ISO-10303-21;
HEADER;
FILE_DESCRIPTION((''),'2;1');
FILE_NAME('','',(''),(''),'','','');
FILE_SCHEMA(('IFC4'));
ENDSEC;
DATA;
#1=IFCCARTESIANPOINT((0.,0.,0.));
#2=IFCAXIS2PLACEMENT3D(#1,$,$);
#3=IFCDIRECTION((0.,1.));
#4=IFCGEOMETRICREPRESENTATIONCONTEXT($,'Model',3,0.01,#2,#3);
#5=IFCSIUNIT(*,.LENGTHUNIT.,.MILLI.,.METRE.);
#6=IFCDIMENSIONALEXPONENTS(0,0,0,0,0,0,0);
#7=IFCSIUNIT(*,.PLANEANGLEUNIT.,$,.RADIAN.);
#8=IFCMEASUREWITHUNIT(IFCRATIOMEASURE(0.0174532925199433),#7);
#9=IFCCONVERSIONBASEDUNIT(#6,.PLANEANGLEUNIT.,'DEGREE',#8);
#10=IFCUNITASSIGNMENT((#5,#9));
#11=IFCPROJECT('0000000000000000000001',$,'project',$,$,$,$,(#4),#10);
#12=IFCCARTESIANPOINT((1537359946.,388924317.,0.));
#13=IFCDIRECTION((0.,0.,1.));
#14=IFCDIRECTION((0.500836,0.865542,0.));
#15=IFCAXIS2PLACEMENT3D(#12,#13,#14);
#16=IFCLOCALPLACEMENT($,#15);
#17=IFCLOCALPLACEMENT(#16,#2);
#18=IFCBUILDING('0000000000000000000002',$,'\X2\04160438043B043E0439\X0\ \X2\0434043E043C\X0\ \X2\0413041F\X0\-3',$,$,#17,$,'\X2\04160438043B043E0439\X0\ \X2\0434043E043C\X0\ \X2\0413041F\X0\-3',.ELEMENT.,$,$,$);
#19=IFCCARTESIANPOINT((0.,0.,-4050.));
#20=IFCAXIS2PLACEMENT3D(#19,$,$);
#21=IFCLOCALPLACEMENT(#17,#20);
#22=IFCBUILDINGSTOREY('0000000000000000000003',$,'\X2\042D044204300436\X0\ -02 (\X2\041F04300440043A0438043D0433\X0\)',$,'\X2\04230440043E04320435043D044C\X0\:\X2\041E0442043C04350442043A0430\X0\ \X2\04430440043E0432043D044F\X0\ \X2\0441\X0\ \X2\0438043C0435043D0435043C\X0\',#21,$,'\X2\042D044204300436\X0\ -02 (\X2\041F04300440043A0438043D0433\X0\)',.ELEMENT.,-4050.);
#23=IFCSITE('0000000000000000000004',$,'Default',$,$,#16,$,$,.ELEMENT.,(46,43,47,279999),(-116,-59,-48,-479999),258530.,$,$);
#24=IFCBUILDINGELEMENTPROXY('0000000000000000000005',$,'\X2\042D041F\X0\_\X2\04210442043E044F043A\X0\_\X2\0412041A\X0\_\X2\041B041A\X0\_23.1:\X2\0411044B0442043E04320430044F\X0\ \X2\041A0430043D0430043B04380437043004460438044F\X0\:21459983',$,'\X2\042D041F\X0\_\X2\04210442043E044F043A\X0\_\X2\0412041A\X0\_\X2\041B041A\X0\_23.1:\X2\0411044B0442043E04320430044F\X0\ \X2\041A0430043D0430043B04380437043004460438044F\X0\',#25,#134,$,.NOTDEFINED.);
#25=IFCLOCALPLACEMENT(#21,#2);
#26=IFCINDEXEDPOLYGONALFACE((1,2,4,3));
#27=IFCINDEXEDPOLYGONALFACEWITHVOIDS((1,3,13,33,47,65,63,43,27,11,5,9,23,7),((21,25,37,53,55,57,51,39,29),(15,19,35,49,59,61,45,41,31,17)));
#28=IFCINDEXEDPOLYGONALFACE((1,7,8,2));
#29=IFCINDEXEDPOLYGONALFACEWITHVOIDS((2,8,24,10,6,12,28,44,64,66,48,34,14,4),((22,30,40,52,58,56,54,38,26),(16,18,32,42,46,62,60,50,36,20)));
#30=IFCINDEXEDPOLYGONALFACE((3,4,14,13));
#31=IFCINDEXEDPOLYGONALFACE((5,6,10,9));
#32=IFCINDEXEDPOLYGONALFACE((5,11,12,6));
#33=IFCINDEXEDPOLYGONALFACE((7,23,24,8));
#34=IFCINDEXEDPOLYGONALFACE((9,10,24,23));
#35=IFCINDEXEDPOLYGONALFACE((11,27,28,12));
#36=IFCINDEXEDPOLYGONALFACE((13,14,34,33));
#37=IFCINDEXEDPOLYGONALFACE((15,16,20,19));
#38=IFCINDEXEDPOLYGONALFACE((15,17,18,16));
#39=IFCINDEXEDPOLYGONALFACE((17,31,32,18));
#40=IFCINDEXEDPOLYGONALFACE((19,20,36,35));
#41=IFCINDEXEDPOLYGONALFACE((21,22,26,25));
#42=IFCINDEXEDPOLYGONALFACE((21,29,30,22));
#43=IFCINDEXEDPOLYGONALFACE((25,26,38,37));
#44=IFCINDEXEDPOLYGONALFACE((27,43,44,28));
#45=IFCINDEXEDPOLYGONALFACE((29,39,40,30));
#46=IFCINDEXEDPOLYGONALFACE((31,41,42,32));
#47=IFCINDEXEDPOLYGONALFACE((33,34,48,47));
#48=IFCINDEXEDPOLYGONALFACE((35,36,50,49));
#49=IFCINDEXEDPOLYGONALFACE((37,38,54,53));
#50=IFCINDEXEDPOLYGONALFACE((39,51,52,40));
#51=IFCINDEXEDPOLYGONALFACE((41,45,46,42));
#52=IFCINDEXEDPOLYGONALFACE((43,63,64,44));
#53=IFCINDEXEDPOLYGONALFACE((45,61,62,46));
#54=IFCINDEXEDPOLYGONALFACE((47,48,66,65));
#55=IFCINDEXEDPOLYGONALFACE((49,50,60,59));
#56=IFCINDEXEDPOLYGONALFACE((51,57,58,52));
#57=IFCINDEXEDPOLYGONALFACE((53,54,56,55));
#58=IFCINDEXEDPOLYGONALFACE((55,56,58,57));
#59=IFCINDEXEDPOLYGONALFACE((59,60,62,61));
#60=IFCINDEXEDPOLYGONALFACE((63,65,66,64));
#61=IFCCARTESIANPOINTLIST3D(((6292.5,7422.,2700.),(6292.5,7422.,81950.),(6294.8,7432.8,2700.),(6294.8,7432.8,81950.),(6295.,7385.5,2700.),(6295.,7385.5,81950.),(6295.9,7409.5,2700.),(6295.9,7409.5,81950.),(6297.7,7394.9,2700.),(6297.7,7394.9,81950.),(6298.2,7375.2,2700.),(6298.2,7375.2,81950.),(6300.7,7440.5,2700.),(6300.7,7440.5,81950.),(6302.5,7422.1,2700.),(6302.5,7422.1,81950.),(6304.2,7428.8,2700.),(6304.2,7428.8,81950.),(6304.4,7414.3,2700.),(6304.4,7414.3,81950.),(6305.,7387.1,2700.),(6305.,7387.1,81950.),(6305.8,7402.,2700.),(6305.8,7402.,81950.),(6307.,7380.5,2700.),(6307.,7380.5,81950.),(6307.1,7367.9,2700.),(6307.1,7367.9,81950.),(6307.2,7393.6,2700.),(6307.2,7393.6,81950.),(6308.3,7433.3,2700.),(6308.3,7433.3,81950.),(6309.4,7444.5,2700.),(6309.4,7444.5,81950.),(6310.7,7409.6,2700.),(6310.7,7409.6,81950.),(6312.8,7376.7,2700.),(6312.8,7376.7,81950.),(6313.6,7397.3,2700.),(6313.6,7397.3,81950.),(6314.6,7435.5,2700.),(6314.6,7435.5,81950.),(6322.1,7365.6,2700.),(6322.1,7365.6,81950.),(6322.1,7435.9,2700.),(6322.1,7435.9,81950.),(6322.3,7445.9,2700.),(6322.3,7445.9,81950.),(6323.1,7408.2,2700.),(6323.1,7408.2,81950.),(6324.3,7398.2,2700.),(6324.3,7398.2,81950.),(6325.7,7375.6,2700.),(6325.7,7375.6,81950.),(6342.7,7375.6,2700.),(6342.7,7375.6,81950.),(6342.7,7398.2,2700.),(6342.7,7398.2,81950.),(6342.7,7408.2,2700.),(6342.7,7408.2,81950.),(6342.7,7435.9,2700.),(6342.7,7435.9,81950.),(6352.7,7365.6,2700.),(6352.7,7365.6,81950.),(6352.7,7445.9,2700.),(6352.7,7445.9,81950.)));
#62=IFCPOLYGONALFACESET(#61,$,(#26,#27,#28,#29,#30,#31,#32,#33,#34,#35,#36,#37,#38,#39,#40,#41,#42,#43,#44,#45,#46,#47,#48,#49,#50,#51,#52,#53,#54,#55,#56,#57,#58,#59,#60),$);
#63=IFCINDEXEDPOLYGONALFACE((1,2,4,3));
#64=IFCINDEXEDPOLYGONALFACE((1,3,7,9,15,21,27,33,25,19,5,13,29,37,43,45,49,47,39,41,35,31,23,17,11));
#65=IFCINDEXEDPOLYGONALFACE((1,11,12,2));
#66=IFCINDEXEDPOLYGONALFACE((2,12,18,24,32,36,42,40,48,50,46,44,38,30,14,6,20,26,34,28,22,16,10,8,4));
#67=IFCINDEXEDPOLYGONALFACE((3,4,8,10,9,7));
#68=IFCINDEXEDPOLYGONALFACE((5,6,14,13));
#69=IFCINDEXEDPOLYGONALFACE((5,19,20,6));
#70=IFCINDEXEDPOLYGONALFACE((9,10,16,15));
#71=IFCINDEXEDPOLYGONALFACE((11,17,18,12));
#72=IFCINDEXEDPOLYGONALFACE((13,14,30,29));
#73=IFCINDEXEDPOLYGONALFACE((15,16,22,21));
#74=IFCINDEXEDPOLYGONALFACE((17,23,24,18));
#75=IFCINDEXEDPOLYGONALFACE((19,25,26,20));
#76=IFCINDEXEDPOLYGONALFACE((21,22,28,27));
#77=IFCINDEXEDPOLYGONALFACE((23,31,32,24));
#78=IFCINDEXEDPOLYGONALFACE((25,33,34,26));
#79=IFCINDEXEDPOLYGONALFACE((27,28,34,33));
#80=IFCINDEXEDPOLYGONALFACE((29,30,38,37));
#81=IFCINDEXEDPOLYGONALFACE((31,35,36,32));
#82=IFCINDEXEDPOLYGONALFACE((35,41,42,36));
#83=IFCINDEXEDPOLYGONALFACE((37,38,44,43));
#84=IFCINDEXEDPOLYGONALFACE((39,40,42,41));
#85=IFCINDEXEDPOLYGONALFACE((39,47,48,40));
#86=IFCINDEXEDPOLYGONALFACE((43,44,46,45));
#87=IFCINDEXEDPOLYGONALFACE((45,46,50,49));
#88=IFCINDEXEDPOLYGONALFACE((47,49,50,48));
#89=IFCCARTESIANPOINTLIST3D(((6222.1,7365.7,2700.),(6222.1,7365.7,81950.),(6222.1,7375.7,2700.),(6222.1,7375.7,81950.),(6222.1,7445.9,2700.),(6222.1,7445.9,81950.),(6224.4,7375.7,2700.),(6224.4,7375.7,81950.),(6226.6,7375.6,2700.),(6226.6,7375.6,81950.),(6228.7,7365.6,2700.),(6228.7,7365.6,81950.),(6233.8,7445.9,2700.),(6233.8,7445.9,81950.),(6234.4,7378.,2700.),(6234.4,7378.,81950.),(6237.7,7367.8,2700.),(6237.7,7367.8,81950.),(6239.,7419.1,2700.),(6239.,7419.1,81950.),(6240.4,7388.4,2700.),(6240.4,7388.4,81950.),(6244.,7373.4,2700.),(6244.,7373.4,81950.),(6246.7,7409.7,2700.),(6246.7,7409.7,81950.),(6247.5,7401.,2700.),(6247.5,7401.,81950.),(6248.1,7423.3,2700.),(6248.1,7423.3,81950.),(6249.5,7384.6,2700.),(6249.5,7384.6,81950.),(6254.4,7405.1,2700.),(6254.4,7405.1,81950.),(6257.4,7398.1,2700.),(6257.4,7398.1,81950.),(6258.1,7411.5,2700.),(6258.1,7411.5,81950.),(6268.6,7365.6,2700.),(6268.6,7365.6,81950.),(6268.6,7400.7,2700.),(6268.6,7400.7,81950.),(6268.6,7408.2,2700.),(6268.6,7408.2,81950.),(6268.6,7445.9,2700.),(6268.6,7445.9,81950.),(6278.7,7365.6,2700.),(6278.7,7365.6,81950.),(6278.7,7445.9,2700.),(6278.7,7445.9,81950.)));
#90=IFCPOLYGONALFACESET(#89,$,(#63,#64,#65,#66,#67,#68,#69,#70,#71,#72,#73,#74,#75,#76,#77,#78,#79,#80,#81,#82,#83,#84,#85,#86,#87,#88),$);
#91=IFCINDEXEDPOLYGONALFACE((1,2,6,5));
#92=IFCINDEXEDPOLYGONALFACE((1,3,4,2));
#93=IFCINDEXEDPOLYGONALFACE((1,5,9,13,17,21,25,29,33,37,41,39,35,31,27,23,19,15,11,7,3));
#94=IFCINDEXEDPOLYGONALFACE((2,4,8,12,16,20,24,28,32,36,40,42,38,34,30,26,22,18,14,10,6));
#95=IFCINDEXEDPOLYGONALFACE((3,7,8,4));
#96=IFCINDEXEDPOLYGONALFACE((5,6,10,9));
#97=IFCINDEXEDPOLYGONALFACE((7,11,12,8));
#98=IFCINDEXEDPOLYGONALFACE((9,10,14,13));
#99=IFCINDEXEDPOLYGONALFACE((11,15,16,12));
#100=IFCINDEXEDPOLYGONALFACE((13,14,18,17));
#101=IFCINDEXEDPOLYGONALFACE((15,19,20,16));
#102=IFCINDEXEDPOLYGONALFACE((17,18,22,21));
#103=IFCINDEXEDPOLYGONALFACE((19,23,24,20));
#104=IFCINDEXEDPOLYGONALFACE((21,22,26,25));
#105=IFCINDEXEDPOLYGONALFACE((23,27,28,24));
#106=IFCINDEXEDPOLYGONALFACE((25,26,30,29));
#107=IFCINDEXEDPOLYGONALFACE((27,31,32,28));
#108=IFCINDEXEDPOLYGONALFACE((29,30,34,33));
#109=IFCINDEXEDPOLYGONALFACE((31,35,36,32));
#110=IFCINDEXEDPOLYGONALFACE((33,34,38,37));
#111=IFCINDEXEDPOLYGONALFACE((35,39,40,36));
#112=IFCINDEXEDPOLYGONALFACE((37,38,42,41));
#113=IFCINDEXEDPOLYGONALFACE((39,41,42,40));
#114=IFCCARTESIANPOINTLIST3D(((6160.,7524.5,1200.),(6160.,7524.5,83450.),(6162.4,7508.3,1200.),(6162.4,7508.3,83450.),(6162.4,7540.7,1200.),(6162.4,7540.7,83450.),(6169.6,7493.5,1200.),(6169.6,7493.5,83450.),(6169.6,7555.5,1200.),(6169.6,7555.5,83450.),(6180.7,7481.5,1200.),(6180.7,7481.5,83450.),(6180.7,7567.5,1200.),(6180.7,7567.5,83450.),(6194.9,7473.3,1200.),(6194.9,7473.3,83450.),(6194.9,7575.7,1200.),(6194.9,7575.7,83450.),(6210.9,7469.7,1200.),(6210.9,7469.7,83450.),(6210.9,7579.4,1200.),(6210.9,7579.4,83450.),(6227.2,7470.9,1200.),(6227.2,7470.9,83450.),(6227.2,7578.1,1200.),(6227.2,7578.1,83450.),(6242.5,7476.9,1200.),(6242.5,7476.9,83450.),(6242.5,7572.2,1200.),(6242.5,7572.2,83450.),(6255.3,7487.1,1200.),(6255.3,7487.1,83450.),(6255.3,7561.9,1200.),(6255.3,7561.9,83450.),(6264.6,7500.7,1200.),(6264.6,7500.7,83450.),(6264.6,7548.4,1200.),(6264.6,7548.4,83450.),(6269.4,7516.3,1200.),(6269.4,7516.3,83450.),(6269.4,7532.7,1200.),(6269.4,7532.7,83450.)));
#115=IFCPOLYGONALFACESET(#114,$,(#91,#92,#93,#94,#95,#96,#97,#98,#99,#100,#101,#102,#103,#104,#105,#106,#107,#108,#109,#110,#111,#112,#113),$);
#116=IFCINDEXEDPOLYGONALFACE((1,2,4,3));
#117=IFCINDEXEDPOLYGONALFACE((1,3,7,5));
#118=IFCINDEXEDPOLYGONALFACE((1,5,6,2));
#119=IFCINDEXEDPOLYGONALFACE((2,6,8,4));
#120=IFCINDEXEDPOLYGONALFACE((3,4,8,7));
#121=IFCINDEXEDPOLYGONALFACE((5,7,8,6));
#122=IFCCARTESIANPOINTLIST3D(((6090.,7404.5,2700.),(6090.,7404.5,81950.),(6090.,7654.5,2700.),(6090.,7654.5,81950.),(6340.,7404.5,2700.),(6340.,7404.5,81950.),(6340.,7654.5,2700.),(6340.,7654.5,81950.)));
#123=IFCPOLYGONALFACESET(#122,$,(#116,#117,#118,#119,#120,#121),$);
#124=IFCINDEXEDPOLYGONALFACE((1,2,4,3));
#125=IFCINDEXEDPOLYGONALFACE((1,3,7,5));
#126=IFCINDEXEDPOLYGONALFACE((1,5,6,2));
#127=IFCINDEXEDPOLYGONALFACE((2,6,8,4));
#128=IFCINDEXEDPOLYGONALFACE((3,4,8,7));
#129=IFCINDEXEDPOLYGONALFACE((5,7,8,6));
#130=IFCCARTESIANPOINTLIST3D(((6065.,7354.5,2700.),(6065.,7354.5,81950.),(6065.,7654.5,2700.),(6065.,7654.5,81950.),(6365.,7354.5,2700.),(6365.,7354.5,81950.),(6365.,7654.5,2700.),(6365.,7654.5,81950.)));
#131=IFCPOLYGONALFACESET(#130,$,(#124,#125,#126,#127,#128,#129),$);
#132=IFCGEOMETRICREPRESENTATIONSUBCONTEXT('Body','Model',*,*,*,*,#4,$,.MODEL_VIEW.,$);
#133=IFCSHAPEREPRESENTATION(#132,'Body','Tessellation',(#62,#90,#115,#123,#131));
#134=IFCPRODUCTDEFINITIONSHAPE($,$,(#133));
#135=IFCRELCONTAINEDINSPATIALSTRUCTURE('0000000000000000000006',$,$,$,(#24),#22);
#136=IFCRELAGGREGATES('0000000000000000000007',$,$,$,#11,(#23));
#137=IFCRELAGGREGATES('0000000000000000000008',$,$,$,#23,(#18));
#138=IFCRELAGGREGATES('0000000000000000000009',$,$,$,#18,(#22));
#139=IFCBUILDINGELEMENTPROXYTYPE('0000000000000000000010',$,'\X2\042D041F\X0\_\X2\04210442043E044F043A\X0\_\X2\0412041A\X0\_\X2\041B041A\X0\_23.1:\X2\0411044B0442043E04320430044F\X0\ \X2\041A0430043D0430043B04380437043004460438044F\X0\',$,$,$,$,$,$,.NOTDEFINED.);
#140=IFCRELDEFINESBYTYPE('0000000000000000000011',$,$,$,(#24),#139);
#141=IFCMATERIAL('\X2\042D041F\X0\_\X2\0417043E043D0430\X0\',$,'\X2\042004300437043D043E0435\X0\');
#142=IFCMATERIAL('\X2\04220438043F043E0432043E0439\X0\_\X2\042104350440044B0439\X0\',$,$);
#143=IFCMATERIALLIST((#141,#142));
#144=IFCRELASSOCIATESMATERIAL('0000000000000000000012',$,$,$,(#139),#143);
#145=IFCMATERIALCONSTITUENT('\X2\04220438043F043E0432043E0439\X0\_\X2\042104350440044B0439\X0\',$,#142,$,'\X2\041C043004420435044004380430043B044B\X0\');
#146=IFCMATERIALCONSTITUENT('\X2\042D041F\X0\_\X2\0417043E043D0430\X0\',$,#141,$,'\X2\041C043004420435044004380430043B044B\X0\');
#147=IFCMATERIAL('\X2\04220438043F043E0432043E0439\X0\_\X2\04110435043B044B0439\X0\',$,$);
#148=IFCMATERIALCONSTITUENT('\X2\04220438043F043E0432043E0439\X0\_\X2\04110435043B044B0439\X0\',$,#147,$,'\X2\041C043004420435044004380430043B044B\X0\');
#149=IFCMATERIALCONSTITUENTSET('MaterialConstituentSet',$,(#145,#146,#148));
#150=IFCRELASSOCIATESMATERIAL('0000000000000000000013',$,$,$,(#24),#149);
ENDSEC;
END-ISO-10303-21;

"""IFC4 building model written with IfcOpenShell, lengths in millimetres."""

from ifc_helpers import new_model, entity, si_unit, converted_unit, direction, frame, frame_2d, origin, place, context, subcontext, project, spatial, polyline, rectangle, circle, outline, extrude, source, transform, mapped, material, material_list, constituent, constituent_set, type_object, type_shapes, element, save


model = new_model("IFC4")

# Units and contexts
model_context = context("Model", 3, precision=0.01, world=origin(), true_north=direction((0.0, 1.0)))
body_context = subcontext(model_context, "Body", "Model", "MODEL_VIEW")
ifc_project = project(units=[si_unit("LENGTHUNIT", "METRE", prefix="MILLI"), converted_unit("PLANEANGLEUNIT", "DEGREE", entity("IfcRatioMeasure", 0.0174532925199433), si_unit("PLANEANGLEUNIT", "RADIAN"), dimensions=[0, 0, 0, 0, 0, 0, 0])], contexts=[model_context])

# Site, building, storey
site_placement = place(None, frame((1537359946.0, 388924317.0, 0.0), z_axis=(0.0, 0.0, 1.0), x_axis=(0.500836, 0.865542, 0.0)))
site = spatial("IfcSite", under=ifc_project, at=site_placement, Name="Default", CompositionType="ELEMENT", RefLatitude=(46, 43, 47, 279999), RefLongitude=(-116, -59, -48, -479999), RefElevation=258530.0)
building_placement = place(site_placement, origin())
building = spatial("IfcBuilding", under=site, at=building_placement, Name="Жилой дом ГП-3", LongName="Жилой дом ГП-3", CompositionType="ELEMENT")
storey_placement = place(building_placement, frame((0.0, 0.0, -4050.0)))
storey = spatial("IfcBuildingStorey", under=building, at=storey_placement, Name="Этаж -02 (Паркинг)", ObjectType="Уровень:Отметка уровня с именем", LongName="Этаж -02 (Паркинг)", CompositionType="ELEMENT", Elevation=-4050.0)

# Building element proxy
ifc_material_1 = material(Name="ЭП_Зона", Category="Разное")
ifc_material_2 = material(Name="Типовой_Белый")
ifc_material_3 = material(Name="Типовой_Серый")
ifc_material_list_1 = material_list([ifc_material_1, ifc_material_3])
building_element_proxy_type_1 = type_object("IfcBuildingElementProxyType", Name="ЭП_Стояк_ВК_ЛК_23.1:Бытовая Канализация", PredefinedType="NOTDEFINED", material=ifc_material_list_1)
shared_shape_1 = source(origin(), body_context, "Body", "SweptSolid", [
    extrude(outline(polyline([(-42.2, -39.0), (-11.8, -39.0), (1.1, -37.6), (9.8, -33.5), (15.7, -25.8), (18.0, -15.0), (14.6, -2.5), (4.7, 5.0), (12.8, 12.1), (15.5, 21.5), (12.3, 31.8), (3.4, 39.0), (-11.6, 41.4), (-42.2, 41.4), (-42.2, -39.0)]), holes=[polyline([(-32.2, 8.8), (-32.2, 31.4), (-15.2, 31.4), (-2.3, 30.3), (3.5, 26.4), (5.5, 19.9), (3.3, 13.3), (-3.1, 9.6), (-13.9, 8.8), (-32.2, 8.8)]), polyline([(-32.2, -28.9), (-32.2, -1.3), (-12.6, -1.3), (-0.2, -2.6), (6.1, -7.3), (8.0, -15.1), (6.3, -21.9), (2.2, -26.3), (-4.1, -28.5), (-11.6, -28.9), (-32.2, -28.9)])]), frame((54.5, -52.4, -1350.0)), (0.0, 0.0, 1.0), 79250.0),
    extrude(outline(polyline([(-32.1, -31.9), (48.3, -31.9), (48.3, -21.8), (10.6, -21.8), (13.8, -11.4), (25.6, -1.3), (48.3, 13.0), (48.3, 24.6), (21.4, 7.7), (12.0, 0.1), (7.4, -7.7), (3.3, -0.7), (-9.3, 6.4), (-19.7, 12.3), (-22.1, 20.2), (-22.0, 22.4), (-22.0, 24.6), (-32.0, 24.6), (-32.1, 18.0), (-29.9, 9.0), (-24.3, 2.8), (-13.1, -2.8), (0.4, -10.6), (3.0, -21.8), (-32.1, -21.8), (-32.1, -31.9)])), frame((118.2, -43.1, -1350.0), z_axis=(0.0, 0.0, 1.0), x_axis=(0.0, -1.0, 0.0)), (0.0, 0.0, 1.0), 79250.0),
    extrude(circle(Radius=55.0, at=frame_2d((0.0, 0.0), x_axis=(1.0, 0.0))), frame((150.0, -170.0, -2850.0)), (0.0, 0.0, 1.0), 82250.0),
    extrude(rectangle(XDim=250.0, YDim=250.0, at=frame_2d((0.0, 0.0), x_axis=(1.0, 0.0))), frame((150.0, -175.0, -1350.0)), (0.0, 0.0, 1.0), 79250.0),
    extrude(rectangle(XDim=300.0, YDim=300.0, at=frame_2d((0.0, 0.0), x_axis=(1.0, 0.0))), frame((150.0, -150.0, -1350.0)), (0.0, 0.0, 1.0), 79250.0),
])
type_shapes(building_element_proxy_type_1, [shared_shape_1])
ifc_constituent_1 = constituent(ifc_material_3, Name="Типовой_Серый", Category="Материалы")
ifc_constituent_2 = constituent(ifc_material_1, Name="ЭП_Зона", Category="Материалы")
ifc_constituent_3 = constituent(ifc_material_2, Name="Типовой_Белый", Category="Материалы")
ifc_constituent_set_1 = constituent_set(constituents=[ifc_constituent_1, ifc_constituent_2, ifc_constituent_3], Name="MaterialConstituentSet")
proxy_1_placement = place(storey_placement, frame((6365.0, 7354.5, 4050.0), z_axis=(0.0, 0.0, 1.0), x_axis=(-1.0, 0.0, 0.0)))
element("IfcBuildingElementProxy", 1, at=proxy_1_placement, inside=storey, type_object=building_element_proxy_type_1, material=ifc_constituent_set_1, Name="ЭП_Стояк_ВК_ЛК_23.1:Бытовая Канализация:21459983", ObjectType="ЭП_Стояк_ВК_ЛК_23.1:Бытовая Канализация", PredefinedType="NOTDEFINED", context=body_context, shape_type="MappedRepresentation", body=[
    mapped(shared_shape_1, transform((0.0, 0.0, 0.0), scale=1.0)),
])

save(model, "model.ifc")
